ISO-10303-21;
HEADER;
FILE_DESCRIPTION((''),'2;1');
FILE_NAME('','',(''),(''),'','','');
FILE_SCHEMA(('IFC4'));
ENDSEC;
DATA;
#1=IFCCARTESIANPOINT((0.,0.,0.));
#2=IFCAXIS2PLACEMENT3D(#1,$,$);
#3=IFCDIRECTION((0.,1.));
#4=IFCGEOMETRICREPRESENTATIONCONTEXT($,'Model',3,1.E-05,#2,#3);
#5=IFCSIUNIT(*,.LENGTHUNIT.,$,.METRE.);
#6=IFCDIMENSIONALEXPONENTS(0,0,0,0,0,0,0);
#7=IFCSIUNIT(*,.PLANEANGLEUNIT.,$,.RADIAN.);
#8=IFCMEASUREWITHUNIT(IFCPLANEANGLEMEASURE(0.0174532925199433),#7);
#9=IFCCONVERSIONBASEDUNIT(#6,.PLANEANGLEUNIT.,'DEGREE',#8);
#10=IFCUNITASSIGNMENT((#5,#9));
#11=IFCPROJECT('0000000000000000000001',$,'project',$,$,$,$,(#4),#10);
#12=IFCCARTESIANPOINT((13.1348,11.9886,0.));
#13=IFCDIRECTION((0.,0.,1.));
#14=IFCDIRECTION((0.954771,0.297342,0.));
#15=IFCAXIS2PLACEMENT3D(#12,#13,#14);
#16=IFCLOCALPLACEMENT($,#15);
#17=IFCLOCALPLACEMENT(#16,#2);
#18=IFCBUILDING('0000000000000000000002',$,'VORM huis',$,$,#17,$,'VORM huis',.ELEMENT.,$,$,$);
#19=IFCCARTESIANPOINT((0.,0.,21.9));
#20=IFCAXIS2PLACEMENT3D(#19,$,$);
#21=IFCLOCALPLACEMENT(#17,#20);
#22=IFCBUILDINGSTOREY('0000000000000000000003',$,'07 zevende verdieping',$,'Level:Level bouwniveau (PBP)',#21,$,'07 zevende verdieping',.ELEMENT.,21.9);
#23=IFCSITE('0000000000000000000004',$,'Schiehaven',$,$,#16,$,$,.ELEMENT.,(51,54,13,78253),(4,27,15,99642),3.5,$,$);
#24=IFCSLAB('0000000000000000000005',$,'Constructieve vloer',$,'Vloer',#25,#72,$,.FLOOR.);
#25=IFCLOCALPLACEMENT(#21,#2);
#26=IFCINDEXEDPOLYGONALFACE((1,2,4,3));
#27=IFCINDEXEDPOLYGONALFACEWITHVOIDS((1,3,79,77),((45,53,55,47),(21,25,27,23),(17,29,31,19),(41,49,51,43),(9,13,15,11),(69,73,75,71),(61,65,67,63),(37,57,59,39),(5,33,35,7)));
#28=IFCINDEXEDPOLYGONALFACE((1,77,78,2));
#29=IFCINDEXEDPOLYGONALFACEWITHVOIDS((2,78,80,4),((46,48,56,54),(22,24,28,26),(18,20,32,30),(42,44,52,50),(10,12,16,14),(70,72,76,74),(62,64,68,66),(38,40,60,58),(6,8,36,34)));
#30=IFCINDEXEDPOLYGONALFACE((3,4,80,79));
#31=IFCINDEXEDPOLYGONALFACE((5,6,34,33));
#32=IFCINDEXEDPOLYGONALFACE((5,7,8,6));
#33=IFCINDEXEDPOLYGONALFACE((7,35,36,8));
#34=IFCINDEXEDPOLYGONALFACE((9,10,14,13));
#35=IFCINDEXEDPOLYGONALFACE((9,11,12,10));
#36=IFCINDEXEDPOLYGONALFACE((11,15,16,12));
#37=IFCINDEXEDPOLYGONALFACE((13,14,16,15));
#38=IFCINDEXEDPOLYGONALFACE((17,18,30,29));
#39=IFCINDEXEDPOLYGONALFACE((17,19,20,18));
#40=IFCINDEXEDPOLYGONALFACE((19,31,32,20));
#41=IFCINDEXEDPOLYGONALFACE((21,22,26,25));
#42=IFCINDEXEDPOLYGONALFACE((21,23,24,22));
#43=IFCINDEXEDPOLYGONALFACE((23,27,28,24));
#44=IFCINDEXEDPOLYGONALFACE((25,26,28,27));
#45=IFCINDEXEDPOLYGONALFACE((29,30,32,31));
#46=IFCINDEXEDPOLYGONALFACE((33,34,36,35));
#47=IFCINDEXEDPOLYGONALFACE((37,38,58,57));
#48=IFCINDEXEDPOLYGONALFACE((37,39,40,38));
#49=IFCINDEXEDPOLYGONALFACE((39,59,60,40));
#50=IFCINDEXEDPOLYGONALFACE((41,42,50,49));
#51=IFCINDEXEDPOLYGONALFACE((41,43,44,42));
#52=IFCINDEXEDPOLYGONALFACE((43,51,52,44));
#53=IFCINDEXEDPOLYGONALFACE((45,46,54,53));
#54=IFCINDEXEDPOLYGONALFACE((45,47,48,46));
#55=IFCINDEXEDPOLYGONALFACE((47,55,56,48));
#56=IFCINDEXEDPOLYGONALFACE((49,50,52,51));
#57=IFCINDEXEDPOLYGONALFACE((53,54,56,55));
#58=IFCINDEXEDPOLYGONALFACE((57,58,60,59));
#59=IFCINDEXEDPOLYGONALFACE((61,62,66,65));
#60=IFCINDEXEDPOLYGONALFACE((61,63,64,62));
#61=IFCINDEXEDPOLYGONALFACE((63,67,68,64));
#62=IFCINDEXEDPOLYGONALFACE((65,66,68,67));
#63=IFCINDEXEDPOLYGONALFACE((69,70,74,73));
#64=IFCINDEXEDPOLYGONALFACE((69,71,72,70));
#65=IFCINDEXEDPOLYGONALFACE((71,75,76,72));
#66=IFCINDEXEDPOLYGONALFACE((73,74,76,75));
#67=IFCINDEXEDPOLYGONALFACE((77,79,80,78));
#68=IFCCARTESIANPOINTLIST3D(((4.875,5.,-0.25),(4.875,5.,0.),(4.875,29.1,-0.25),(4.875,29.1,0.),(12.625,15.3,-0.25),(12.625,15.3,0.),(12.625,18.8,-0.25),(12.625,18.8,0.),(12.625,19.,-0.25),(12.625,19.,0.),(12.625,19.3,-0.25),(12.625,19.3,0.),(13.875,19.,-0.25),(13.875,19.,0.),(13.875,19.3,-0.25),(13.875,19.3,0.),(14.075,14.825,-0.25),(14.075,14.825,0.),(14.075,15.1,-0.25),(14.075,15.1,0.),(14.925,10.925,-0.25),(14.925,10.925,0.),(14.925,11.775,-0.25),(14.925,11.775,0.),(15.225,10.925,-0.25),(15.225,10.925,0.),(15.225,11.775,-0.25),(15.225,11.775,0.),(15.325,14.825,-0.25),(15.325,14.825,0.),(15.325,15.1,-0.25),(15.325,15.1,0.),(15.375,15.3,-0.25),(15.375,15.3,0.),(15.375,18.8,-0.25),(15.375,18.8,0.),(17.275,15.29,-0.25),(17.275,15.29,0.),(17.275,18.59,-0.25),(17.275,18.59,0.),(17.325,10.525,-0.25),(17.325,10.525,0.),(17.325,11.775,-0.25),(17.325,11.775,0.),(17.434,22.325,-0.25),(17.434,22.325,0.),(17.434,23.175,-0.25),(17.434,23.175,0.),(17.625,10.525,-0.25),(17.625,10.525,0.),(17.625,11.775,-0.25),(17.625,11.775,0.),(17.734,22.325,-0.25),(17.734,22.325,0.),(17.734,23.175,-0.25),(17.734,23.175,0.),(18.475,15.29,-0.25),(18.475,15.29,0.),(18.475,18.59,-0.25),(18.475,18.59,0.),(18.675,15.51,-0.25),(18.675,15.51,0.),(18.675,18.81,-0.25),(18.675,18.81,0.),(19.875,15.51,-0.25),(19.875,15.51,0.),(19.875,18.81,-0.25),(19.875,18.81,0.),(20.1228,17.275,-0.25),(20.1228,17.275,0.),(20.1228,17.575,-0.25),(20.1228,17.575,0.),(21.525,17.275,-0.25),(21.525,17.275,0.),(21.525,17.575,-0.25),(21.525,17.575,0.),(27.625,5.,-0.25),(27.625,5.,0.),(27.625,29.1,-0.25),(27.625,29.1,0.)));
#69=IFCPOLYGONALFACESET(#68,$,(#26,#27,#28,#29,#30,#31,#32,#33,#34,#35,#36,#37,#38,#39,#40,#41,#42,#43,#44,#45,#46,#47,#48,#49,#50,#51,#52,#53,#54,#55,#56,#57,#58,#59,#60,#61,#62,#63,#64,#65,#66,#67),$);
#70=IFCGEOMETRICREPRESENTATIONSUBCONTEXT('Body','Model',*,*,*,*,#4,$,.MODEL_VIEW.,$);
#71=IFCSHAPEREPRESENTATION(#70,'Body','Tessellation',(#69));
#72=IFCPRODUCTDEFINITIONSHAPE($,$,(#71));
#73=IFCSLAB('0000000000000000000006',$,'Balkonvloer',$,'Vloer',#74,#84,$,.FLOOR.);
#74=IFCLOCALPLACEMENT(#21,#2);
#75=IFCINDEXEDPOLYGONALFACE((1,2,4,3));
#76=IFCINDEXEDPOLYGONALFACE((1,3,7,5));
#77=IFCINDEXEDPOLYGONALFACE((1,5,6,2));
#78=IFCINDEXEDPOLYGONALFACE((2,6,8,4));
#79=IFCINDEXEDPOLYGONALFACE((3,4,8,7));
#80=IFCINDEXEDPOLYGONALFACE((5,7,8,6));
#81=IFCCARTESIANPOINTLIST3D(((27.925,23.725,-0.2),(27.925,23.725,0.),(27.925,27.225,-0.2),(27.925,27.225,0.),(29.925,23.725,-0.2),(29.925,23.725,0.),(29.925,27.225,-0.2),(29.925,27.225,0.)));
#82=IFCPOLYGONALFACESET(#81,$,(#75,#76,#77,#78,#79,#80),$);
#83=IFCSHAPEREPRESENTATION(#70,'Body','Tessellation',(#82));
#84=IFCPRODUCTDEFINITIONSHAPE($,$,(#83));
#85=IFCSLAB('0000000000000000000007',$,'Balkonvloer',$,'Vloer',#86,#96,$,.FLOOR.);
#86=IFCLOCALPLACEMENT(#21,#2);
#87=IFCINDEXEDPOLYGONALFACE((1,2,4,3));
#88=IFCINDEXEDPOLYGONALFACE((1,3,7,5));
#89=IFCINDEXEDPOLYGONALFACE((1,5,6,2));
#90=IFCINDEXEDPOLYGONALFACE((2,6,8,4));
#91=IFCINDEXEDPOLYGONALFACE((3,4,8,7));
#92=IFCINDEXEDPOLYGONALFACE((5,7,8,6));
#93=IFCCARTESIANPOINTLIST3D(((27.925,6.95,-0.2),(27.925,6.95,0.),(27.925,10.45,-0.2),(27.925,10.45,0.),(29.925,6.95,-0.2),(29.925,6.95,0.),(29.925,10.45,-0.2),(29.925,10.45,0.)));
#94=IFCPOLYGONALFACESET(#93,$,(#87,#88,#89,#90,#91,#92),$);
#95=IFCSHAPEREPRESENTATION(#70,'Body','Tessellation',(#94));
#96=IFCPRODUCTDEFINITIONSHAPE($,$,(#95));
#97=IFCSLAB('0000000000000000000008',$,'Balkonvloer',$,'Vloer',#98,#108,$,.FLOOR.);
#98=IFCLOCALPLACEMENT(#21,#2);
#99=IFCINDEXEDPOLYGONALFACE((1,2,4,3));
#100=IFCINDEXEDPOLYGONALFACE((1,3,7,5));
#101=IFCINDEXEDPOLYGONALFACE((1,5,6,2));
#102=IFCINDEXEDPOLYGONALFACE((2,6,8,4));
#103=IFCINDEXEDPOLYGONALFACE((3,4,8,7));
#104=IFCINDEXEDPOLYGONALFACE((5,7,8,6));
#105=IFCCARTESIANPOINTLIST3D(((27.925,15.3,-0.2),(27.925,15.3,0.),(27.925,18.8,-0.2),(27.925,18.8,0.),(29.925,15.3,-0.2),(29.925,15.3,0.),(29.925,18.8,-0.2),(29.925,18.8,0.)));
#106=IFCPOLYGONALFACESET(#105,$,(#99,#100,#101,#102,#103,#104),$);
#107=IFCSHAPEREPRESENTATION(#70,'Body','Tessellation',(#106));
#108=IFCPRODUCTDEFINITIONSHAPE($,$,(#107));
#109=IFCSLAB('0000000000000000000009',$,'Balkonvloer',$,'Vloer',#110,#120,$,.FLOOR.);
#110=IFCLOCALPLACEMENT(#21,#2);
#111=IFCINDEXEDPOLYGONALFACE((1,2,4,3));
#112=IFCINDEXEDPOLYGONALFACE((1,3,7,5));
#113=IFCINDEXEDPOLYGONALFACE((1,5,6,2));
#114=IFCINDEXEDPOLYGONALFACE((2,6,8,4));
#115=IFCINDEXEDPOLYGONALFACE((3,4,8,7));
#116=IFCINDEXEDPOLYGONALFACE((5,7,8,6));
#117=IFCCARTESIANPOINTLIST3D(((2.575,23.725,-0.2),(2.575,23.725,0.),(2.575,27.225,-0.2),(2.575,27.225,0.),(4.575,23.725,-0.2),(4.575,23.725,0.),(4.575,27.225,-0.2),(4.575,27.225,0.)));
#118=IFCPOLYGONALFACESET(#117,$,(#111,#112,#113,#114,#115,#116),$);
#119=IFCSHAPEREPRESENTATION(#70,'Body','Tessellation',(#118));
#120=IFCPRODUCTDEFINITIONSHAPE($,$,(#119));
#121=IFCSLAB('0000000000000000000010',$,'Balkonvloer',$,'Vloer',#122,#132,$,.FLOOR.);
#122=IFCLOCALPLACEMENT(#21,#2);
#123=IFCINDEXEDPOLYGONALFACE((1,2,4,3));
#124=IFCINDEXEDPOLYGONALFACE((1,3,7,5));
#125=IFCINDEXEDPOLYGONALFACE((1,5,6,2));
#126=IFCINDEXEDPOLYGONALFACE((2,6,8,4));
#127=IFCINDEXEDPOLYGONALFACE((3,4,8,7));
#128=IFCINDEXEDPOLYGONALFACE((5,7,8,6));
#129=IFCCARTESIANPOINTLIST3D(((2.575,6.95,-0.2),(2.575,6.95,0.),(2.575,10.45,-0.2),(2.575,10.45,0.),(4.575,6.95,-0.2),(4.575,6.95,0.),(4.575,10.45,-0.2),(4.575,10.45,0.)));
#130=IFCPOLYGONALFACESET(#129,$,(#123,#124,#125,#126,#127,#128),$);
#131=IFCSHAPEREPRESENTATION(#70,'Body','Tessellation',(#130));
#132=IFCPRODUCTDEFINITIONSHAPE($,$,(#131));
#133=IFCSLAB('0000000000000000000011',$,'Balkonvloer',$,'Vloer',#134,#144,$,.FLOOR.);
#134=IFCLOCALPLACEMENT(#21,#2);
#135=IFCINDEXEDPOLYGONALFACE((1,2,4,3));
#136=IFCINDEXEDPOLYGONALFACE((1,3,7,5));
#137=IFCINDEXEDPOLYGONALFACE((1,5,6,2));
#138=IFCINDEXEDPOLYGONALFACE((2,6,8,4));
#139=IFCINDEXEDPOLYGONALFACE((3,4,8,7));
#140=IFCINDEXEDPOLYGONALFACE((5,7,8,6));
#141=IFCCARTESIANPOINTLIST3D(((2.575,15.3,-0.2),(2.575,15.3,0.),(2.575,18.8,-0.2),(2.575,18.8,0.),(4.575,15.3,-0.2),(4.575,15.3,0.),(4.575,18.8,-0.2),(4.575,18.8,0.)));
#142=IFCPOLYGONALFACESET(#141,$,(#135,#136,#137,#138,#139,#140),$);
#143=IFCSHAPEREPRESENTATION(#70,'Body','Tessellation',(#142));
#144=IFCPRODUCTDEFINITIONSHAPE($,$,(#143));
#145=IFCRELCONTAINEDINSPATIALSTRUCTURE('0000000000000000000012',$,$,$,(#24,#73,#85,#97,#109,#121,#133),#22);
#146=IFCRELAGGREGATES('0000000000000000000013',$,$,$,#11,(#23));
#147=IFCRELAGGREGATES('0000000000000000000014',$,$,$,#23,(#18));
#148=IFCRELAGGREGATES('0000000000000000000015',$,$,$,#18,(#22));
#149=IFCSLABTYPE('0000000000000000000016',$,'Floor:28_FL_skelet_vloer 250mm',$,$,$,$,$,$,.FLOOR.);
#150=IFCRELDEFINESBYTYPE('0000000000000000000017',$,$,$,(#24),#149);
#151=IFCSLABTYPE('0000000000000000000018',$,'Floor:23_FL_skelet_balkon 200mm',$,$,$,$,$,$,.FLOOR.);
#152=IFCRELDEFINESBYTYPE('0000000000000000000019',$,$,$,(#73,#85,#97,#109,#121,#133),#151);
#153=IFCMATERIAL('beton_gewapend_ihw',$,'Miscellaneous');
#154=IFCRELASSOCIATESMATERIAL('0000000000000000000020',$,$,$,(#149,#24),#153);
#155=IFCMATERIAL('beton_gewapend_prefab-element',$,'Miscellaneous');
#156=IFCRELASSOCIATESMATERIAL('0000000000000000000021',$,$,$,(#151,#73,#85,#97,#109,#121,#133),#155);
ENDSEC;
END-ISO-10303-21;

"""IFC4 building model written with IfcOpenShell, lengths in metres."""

from ifc_helpers import new_model, entity, si_unit, converted_unit, direction, frame, origin, place, context, subcontext, project, spatial, indexed_curve, outline, extrude, material, type_object, element, save


model = new_model("IFC4")

# Units and contexts
model_context = context("Model", 3, precision=1e-05, world=origin(), true_north=direction((0.0, 1.0)))
body_context = subcontext(model_context, "Body", "Model", "MODEL_VIEW")
ifc_project = project(units=[si_unit("LENGTHUNIT", "METRE"), converted_unit("PLANEANGLEUNIT", "DEGREE", entity("IfcPlaneAngleMeasure", 0.0174532925199433), si_unit("PLANEANGLEUNIT", "RADIAN"), dimensions=[0, 0, 0, 0, 0, 0, 0])], contexts=[model_context])

# Site, building, storey
site_placement = place(None, frame((13.1348, 11.9886, 0.0), z_axis=(0.0, 0.0, 1.0), x_axis=(0.954771, 0.297342, 0.0)))
site = spatial("IfcSite", under=ifc_project, at=site_placement, Name="Schiehaven", CompositionType="ELEMENT", RefLatitude=(51, 54, 13, 78253), RefLongitude=(4, 27, 15, 99642), RefElevation=3.5)
building_placement = place(site_placement, origin())
building = spatial("IfcBuilding", under=site, at=building_placement, Name="VORM huis", LongName="VORM huis", CompositionType="ELEMENT")
storey_placement = place(building_placement, frame((0.0, 0.0, 21.9)))
storey = spatial("IfcBuildingStorey", under=building, at=storey_placement, Name="07 zevende verdieping", ObjectType="Level:Level bouwniveau (PBP)", LongName="07 zevende verdieping", CompositionType="ELEMENT", Elevation=21.9)

# Slab, openings
ifc_material_1 = material(Name="beton_gewapend_ihw", Category="Miscellaneous")
slab_type_1 = type_object("IfcSlabType", Name="Floor:28_FL_skelet_vloer 250mm", PredefinedType="FLOOR", material=ifc_material_1)
slab_1_placement = place(storey_placement, origin())
slab_1 = element("IfcSlab", 1, at=slab_1_placement, inside=storey, type_object=slab_type_1, material=ifc_material_1, Name="Constructieve vloer", ObjectType="Vloer", PredefinedType="FLOOR", context=body_context, shape_type="SweptSolid", body=[
    extrude(outline(indexed_curve([(-12.05, -11.375), (12.05, -11.375), (12.05, 11.375), (-12.05, 11.375), (-12.05, -11.375)], self_intersect=False), holes=[indexed_curve([(-1.75, -3.625), (-1.75, -0.875), (1.75, -0.875), (1.75, -3.625), (-1.75, -3.625)], self_intersect=False), indexed_curve([(1.76, 2.225), (1.76, 1.025), (-1.54, 1.025), (-1.54, 2.225), (1.76, 2.225)], self_intersect=False), indexed_curve([(-1.76, 3.625), (1.54, 3.625), (1.54, 2.425), (-1.76, 2.425), (-1.76, 3.625)], self_intersect=False), indexed_curve([(5.275, -1.025), (6.125, -1.025), (6.125, -1.325), (5.275, -1.325), (5.275, -1.025)], self_intersect=False), indexed_curve([(5.275, 1.375), (6.525, 1.375), (6.525, 1.075), (5.275, 1.075), (5.275, 1.375)], self_intersect=False), indexed_curve([(-0.525, 5.275), (-0.225, 5.275), (-0.225, 3.8728), (-0.525, 3.8728), (-0.525, 5.275)], self_intersect=False), indexed_curve([(-6.125, 1.484), (-5.275, 1.484), (-5.275, 1.184), (-6.125, 1.184), (-6.125, 1.484)], self_intersect=False), indexed_curve([(1.95, -0.925), (2.225, -0.925), (2.225, -2.175), (1.95, -2.175), (1.95, -0.925)], self_intersect=False), indexed_curve([(-2.25, -2.375), (-1.95, -2.375), (-1.95, -3.625), (-2.25, -3.625), (-2.25, -2.375)], self_intersect=False)]), frame((16.25, 17.05, -0.25), z_axis=(0.0, 0.0, 1.0), x_axis=(0.0, -1.0, 0.0)), (0.0, 0.0, 1.0), 0.25),
])
opening_1_placement = place(slab_1_placement, origin())
element("IfcOpeningElement", 2, at=opening_1_placement, cuts=slab_1, PredefinedType="OPENING", context=body_context, shape_type="SweptSolid", body=[
    extrude(outline(indexed_curve([(-1.75, -1.375), (1.75, -1.375), (1.75, 1.375), (-1.75, 1.375), (-1.75, -1.375)], self_intersect=False)), frame((14.0, 17.05, -0.25), z_axis=(0.0, 0.0, 1.0), x_axis=(0.0, -1.0, 0.0)), (0.0, 0.0, 1.0), 0.25),
])
opening_2_placement = place(slab_1_placement, origin())
element("IfcOpeningElement", 3, at=opening_2_placement, cuts=slab_1, PredefinedType="OPENING", context=body_context, shape_type="SweptSolid", body=[
    extrude(outline(indexed_curve([(-1.65, -0.6), (1.65, -0.6), (1.65, 0.6), (-1.65, 0.6), (-1.65, -0.6)], self_intersect=False)), frame((17.875, 16.94, -0.25), z_axis=(0.0, 0.0, 1.0), x_axis=(0.0, 1.0, 0.0)), (0.0, 0.0, 1.0), 0.25),
])
opening_3_placement = place(slab_1_placement, origin())
element("IfcOpeningElement", 4, at=opening_3_placement, cuts=slab_1, PredefinedType="OPENING", context=body_context, shape_type="SweptSolid", body=[
    extrude(outline(indexed_curve([(-0.15, -0.425), (0.15, -0.425), (0.15, 0.425), (-0.15, 0.425), (-0.15, -0.425)], self_intersect=False)), frame((15.075, 11.35, -0.25), z_axis=(0.0, 0.0, 1.0), x_axis=(-1.0, 0.0, 0.0)), (0.0, 0.0, 1.0), 0.25),
])
opening_4_placement = place(slab_1_placement, origin())
element("IfcOpeningElement", 5, at=opening_4_placement, cuts=slab_1, PredefinedType="OPENING", context=body_context, shape_type="SweptSolid", body=[
    extrude(outline(indexed_curve([(-0.15, -0.625), (0.15, -0.625), (0.15, 0.625), (-0.15, 0.625), (-0.15, -0.625)], self_intersect=False)), frame((17.475, 11.15, -0.25), z_axis=(0.0, 0.0, 1.0), x_axis=(-1.0, 0.0, 0.0)), (0.0, 0.0, 1.0), 0.25),
])
opening_5_placement = place(slab_1_placement, origin())
element("IfcOpeningElement", 6, at=opening_5_placement, cuts=slab_1, PredefinedType="OPENING", context=body_context, shape_type="SweptSolid", body=[
    extrude(outline(indexed_curve([(-0.7011, -0.15), (0.7011, -0.15), (0.7011, 0.15), (-0.7011, 0.15), (-0.7011, -0.15)], self_intersect=False)), frame((20.8239, 17.425, -0.25), z_axis=(0.0, 0.0, 1.0), x_axis=(-1.0, 0.0, 0.0)), (0.0, 0.0, 1.0), 0.25),
])
opening_6_placement = place(slab_1_placement, origin())
element("IfcOpeningElement", 7, at=opening_6_placement, cuts=slab_1, PredefinedType="OPENING", context=body_context, shape_type="SweptSolid", body=[
    extrude(outline(indexed_curve([(-0.15, -0.425), (0.15, -0.425), (0.15, 0.425), (-0.15, 0.425), (-0.15, -0.425)], self_intersect=False)), frame((17.584, 22.75, -0.25), z_axis=(0.0, 0.0, 1.0), x_axis=(-1.0, 0.0, 0.0)), (0.0, 0.0, 1.0), 0.25),
])
opening_7_placement = place(slab_1_placement, origin())
element("IfcOpeningElement", 8, at=opening_7_placement, cuts=slab_1, PredefinedType="OPENING", context=body_context, shape_type="SweptSolid", body=[
    extrude(outline(indexed_curve([(-0.625, -0.1375), (0.625, -0.1375), (0.625, 0.1375), (-0.625, 0.1375), (-0.625, -0.1375)], self_intersect=False)), frame((14.7, 14.9625, -0.25), z_axis=(0.0, 0.0, 1.0), x_axis=(-1.0, 0.0, 0.0)), (0.0, 0.0, 1.0), 0.25),
])
opening_8_placement = place(slab_1_placement, origin())
element("IfcOpeningElement", 9, at=opening_8_placement, cuts=slab_1, PredefinedType="OPENING", context=body_context, shape_type="SweptSolid", body=[
    extrude(outline(indexed_curve([(-0.625, -0.15), (0.625, -0.15), (0.625, 0.15), (-0.625, 0.15), (-0.625, -0.15)], self_intersect=False)), frame((13.25, 19.15, -0.25), z_axis=(0.0, 0.0, 1.0), x_axis=(-1.0, 0.0, 0.0)), (0.0, 0.0, 1.0), 0.25),
])

# Slabs
ifc_material_2 = material(Name="beton_gewapend_prefab-element", Category="Miscellaneous")
slab_type_2 = type_object("IfcSlabType", Name="Floor:23_FL_skelet_balkon 200mm", PredefinedType="FLOOR", material=ifc_material_2)
slab_2_placement = place(storey_placement, origin())
element("IfcSlab", 10, at=slab_2_placement, inside=storey, type_object=slab_type_2, material=ifc_material_2, Name="Balkonvloer", ObjectType="Vloer", PredefinedType="FLOOR", context=body_context, shape_type="SweptSolid", body=[
    extrude(outline(indexed_curve([(-1.75, -1.0), (1.75, -1.0), (1.75, 1.0), (-1.75, 1.0), (-1.75, -1.0)], self_intersect=False)), frame((28.925, 25.475, 0.0), z_axis=(0.0, 0.0, -1.0), x_axis=(0.0, 1.0, 0.0)), (0.0, 0.0, 1.0), 0.2),
])
slab_3_placement = place(storey_placement, origin())
element("IfcSlab", 11, at=slab_3_placement, inside=storey, type_object=slab_type_2, material=ifc_material_2, Name="Balkonvloer", ObjectType="Vloer", PredefinedType="FLOOR", context=body_context, shape_type="SweptSolid", body=[
    extrude(outline(indexed_curve([(-1.75, -1.0), (1.75, -1.0), (1.75, 1.0), (-1.75, 1.0), (-1.75, -1.0)], self_intersect=False)), frame((28.925, 8.7, 0.0), z_axis=(0.0, 0.0, -1.0), x_axis=(0.0, 1.0, 0.0)), (0.0, 0.0, 1.0), 0.2),
])
slab_4_placement = place(storey_placement, origin())
element("IfcSlab", 12, at=slab_4_placement, inside=storey, type_object=slab_type_2, material=ifc_material_2, Name="Balkonvloer", ObjectType="Vloer", PredefinedType="FLOOR", context=body_context, shape_type="SweptSolid", body=[
    extrude(outline(indexed_curve([(-1.75, -1.0), (1.75, -1.0), (1.75, 1.0), (-1.75, 1.0), (-1.75, -1.0)], self_intersect=False)), frame((28.925, 17.05, 0.0), z_axis=(0.0, 0.0, -1.0), x_axis=(0.0, 1.0, 0.0)), (0.0, 0.0, 1.0), 0.2),
])
slab_5_placement = place(storey_placement, origin())
element("IfcSlab", 13, at=slab_5_placement, inside=storey, type_object=slab_type_2, material=ifc_material_2, Name="Balkonvloer", ObjectType="Vloer", PredefinedType="FLOOR", context=body_context, shape_type="SweptSolid", body=[
    extrude(outline(indexed_curve([(-1.75, -1.0), (1.75, -1.0), (1.75, 1.0), (-1.75, 1.0), (-1.75, -1.0)], self_intersect=False)), frame((3.575, 25.475, 0.0), z_axis=(0.0, 0.0, -1.0), x_axis=(0.0, 1.0, 0.0)), (0.0, 0.0, 1.0), 0.2),
])
slab_6_placement = place(storey_placement, origin())
element("IfcSlab", 14, at=slab_6_placement, inside=storey, type_object=slab_type_2, material=ifc_material_2, Name="Balkonvloer", ObjectType="Vloer", PredefinedType="FLOOR", context=body_context, shape_type="SweptSolid", body=[
    extrude(outline(indexed_curve([(-1.75, -1.0), (1.75, -1.0), (1.75, 1.0), (-1.75, 1.0), (-1.75, -1.0)], self_intersect=False)), frame((3.575, 8.7, 0.0), z_axis=(0.0, 0.0, -1.0), x_axis=(0.0, 1.0, 0.0)), (0.0, 0.0, 1.0), 0.2),
])
slab_7_placement = place(storey_placement, origin())
element("IfcSlab", 15, at=slab_7_placement, inside=storey, type_object=slab_type_2, material=ifc_material_2, Name="Balkonvloer", ObjectType="Vloer", PredefinedType="FLOOR", context=body_context, shape_type="SweptSolid", body=[
    extrude(outline(indexed_curve([(-1.75, -1.0), (1.75, -1.0), (1.75, 1.0), (-1.75, 1.0), (-1.75, -1.0)], self_intersect=False)), frame((3.575, 17.05, 0.0), z_axis=(0.0, 0.0, -1.0), x_axis=(0.0, 1.0, 0.0)), (0.0, 0.0, 1.0), 0.2),
])

save(model, "model.ifc")
